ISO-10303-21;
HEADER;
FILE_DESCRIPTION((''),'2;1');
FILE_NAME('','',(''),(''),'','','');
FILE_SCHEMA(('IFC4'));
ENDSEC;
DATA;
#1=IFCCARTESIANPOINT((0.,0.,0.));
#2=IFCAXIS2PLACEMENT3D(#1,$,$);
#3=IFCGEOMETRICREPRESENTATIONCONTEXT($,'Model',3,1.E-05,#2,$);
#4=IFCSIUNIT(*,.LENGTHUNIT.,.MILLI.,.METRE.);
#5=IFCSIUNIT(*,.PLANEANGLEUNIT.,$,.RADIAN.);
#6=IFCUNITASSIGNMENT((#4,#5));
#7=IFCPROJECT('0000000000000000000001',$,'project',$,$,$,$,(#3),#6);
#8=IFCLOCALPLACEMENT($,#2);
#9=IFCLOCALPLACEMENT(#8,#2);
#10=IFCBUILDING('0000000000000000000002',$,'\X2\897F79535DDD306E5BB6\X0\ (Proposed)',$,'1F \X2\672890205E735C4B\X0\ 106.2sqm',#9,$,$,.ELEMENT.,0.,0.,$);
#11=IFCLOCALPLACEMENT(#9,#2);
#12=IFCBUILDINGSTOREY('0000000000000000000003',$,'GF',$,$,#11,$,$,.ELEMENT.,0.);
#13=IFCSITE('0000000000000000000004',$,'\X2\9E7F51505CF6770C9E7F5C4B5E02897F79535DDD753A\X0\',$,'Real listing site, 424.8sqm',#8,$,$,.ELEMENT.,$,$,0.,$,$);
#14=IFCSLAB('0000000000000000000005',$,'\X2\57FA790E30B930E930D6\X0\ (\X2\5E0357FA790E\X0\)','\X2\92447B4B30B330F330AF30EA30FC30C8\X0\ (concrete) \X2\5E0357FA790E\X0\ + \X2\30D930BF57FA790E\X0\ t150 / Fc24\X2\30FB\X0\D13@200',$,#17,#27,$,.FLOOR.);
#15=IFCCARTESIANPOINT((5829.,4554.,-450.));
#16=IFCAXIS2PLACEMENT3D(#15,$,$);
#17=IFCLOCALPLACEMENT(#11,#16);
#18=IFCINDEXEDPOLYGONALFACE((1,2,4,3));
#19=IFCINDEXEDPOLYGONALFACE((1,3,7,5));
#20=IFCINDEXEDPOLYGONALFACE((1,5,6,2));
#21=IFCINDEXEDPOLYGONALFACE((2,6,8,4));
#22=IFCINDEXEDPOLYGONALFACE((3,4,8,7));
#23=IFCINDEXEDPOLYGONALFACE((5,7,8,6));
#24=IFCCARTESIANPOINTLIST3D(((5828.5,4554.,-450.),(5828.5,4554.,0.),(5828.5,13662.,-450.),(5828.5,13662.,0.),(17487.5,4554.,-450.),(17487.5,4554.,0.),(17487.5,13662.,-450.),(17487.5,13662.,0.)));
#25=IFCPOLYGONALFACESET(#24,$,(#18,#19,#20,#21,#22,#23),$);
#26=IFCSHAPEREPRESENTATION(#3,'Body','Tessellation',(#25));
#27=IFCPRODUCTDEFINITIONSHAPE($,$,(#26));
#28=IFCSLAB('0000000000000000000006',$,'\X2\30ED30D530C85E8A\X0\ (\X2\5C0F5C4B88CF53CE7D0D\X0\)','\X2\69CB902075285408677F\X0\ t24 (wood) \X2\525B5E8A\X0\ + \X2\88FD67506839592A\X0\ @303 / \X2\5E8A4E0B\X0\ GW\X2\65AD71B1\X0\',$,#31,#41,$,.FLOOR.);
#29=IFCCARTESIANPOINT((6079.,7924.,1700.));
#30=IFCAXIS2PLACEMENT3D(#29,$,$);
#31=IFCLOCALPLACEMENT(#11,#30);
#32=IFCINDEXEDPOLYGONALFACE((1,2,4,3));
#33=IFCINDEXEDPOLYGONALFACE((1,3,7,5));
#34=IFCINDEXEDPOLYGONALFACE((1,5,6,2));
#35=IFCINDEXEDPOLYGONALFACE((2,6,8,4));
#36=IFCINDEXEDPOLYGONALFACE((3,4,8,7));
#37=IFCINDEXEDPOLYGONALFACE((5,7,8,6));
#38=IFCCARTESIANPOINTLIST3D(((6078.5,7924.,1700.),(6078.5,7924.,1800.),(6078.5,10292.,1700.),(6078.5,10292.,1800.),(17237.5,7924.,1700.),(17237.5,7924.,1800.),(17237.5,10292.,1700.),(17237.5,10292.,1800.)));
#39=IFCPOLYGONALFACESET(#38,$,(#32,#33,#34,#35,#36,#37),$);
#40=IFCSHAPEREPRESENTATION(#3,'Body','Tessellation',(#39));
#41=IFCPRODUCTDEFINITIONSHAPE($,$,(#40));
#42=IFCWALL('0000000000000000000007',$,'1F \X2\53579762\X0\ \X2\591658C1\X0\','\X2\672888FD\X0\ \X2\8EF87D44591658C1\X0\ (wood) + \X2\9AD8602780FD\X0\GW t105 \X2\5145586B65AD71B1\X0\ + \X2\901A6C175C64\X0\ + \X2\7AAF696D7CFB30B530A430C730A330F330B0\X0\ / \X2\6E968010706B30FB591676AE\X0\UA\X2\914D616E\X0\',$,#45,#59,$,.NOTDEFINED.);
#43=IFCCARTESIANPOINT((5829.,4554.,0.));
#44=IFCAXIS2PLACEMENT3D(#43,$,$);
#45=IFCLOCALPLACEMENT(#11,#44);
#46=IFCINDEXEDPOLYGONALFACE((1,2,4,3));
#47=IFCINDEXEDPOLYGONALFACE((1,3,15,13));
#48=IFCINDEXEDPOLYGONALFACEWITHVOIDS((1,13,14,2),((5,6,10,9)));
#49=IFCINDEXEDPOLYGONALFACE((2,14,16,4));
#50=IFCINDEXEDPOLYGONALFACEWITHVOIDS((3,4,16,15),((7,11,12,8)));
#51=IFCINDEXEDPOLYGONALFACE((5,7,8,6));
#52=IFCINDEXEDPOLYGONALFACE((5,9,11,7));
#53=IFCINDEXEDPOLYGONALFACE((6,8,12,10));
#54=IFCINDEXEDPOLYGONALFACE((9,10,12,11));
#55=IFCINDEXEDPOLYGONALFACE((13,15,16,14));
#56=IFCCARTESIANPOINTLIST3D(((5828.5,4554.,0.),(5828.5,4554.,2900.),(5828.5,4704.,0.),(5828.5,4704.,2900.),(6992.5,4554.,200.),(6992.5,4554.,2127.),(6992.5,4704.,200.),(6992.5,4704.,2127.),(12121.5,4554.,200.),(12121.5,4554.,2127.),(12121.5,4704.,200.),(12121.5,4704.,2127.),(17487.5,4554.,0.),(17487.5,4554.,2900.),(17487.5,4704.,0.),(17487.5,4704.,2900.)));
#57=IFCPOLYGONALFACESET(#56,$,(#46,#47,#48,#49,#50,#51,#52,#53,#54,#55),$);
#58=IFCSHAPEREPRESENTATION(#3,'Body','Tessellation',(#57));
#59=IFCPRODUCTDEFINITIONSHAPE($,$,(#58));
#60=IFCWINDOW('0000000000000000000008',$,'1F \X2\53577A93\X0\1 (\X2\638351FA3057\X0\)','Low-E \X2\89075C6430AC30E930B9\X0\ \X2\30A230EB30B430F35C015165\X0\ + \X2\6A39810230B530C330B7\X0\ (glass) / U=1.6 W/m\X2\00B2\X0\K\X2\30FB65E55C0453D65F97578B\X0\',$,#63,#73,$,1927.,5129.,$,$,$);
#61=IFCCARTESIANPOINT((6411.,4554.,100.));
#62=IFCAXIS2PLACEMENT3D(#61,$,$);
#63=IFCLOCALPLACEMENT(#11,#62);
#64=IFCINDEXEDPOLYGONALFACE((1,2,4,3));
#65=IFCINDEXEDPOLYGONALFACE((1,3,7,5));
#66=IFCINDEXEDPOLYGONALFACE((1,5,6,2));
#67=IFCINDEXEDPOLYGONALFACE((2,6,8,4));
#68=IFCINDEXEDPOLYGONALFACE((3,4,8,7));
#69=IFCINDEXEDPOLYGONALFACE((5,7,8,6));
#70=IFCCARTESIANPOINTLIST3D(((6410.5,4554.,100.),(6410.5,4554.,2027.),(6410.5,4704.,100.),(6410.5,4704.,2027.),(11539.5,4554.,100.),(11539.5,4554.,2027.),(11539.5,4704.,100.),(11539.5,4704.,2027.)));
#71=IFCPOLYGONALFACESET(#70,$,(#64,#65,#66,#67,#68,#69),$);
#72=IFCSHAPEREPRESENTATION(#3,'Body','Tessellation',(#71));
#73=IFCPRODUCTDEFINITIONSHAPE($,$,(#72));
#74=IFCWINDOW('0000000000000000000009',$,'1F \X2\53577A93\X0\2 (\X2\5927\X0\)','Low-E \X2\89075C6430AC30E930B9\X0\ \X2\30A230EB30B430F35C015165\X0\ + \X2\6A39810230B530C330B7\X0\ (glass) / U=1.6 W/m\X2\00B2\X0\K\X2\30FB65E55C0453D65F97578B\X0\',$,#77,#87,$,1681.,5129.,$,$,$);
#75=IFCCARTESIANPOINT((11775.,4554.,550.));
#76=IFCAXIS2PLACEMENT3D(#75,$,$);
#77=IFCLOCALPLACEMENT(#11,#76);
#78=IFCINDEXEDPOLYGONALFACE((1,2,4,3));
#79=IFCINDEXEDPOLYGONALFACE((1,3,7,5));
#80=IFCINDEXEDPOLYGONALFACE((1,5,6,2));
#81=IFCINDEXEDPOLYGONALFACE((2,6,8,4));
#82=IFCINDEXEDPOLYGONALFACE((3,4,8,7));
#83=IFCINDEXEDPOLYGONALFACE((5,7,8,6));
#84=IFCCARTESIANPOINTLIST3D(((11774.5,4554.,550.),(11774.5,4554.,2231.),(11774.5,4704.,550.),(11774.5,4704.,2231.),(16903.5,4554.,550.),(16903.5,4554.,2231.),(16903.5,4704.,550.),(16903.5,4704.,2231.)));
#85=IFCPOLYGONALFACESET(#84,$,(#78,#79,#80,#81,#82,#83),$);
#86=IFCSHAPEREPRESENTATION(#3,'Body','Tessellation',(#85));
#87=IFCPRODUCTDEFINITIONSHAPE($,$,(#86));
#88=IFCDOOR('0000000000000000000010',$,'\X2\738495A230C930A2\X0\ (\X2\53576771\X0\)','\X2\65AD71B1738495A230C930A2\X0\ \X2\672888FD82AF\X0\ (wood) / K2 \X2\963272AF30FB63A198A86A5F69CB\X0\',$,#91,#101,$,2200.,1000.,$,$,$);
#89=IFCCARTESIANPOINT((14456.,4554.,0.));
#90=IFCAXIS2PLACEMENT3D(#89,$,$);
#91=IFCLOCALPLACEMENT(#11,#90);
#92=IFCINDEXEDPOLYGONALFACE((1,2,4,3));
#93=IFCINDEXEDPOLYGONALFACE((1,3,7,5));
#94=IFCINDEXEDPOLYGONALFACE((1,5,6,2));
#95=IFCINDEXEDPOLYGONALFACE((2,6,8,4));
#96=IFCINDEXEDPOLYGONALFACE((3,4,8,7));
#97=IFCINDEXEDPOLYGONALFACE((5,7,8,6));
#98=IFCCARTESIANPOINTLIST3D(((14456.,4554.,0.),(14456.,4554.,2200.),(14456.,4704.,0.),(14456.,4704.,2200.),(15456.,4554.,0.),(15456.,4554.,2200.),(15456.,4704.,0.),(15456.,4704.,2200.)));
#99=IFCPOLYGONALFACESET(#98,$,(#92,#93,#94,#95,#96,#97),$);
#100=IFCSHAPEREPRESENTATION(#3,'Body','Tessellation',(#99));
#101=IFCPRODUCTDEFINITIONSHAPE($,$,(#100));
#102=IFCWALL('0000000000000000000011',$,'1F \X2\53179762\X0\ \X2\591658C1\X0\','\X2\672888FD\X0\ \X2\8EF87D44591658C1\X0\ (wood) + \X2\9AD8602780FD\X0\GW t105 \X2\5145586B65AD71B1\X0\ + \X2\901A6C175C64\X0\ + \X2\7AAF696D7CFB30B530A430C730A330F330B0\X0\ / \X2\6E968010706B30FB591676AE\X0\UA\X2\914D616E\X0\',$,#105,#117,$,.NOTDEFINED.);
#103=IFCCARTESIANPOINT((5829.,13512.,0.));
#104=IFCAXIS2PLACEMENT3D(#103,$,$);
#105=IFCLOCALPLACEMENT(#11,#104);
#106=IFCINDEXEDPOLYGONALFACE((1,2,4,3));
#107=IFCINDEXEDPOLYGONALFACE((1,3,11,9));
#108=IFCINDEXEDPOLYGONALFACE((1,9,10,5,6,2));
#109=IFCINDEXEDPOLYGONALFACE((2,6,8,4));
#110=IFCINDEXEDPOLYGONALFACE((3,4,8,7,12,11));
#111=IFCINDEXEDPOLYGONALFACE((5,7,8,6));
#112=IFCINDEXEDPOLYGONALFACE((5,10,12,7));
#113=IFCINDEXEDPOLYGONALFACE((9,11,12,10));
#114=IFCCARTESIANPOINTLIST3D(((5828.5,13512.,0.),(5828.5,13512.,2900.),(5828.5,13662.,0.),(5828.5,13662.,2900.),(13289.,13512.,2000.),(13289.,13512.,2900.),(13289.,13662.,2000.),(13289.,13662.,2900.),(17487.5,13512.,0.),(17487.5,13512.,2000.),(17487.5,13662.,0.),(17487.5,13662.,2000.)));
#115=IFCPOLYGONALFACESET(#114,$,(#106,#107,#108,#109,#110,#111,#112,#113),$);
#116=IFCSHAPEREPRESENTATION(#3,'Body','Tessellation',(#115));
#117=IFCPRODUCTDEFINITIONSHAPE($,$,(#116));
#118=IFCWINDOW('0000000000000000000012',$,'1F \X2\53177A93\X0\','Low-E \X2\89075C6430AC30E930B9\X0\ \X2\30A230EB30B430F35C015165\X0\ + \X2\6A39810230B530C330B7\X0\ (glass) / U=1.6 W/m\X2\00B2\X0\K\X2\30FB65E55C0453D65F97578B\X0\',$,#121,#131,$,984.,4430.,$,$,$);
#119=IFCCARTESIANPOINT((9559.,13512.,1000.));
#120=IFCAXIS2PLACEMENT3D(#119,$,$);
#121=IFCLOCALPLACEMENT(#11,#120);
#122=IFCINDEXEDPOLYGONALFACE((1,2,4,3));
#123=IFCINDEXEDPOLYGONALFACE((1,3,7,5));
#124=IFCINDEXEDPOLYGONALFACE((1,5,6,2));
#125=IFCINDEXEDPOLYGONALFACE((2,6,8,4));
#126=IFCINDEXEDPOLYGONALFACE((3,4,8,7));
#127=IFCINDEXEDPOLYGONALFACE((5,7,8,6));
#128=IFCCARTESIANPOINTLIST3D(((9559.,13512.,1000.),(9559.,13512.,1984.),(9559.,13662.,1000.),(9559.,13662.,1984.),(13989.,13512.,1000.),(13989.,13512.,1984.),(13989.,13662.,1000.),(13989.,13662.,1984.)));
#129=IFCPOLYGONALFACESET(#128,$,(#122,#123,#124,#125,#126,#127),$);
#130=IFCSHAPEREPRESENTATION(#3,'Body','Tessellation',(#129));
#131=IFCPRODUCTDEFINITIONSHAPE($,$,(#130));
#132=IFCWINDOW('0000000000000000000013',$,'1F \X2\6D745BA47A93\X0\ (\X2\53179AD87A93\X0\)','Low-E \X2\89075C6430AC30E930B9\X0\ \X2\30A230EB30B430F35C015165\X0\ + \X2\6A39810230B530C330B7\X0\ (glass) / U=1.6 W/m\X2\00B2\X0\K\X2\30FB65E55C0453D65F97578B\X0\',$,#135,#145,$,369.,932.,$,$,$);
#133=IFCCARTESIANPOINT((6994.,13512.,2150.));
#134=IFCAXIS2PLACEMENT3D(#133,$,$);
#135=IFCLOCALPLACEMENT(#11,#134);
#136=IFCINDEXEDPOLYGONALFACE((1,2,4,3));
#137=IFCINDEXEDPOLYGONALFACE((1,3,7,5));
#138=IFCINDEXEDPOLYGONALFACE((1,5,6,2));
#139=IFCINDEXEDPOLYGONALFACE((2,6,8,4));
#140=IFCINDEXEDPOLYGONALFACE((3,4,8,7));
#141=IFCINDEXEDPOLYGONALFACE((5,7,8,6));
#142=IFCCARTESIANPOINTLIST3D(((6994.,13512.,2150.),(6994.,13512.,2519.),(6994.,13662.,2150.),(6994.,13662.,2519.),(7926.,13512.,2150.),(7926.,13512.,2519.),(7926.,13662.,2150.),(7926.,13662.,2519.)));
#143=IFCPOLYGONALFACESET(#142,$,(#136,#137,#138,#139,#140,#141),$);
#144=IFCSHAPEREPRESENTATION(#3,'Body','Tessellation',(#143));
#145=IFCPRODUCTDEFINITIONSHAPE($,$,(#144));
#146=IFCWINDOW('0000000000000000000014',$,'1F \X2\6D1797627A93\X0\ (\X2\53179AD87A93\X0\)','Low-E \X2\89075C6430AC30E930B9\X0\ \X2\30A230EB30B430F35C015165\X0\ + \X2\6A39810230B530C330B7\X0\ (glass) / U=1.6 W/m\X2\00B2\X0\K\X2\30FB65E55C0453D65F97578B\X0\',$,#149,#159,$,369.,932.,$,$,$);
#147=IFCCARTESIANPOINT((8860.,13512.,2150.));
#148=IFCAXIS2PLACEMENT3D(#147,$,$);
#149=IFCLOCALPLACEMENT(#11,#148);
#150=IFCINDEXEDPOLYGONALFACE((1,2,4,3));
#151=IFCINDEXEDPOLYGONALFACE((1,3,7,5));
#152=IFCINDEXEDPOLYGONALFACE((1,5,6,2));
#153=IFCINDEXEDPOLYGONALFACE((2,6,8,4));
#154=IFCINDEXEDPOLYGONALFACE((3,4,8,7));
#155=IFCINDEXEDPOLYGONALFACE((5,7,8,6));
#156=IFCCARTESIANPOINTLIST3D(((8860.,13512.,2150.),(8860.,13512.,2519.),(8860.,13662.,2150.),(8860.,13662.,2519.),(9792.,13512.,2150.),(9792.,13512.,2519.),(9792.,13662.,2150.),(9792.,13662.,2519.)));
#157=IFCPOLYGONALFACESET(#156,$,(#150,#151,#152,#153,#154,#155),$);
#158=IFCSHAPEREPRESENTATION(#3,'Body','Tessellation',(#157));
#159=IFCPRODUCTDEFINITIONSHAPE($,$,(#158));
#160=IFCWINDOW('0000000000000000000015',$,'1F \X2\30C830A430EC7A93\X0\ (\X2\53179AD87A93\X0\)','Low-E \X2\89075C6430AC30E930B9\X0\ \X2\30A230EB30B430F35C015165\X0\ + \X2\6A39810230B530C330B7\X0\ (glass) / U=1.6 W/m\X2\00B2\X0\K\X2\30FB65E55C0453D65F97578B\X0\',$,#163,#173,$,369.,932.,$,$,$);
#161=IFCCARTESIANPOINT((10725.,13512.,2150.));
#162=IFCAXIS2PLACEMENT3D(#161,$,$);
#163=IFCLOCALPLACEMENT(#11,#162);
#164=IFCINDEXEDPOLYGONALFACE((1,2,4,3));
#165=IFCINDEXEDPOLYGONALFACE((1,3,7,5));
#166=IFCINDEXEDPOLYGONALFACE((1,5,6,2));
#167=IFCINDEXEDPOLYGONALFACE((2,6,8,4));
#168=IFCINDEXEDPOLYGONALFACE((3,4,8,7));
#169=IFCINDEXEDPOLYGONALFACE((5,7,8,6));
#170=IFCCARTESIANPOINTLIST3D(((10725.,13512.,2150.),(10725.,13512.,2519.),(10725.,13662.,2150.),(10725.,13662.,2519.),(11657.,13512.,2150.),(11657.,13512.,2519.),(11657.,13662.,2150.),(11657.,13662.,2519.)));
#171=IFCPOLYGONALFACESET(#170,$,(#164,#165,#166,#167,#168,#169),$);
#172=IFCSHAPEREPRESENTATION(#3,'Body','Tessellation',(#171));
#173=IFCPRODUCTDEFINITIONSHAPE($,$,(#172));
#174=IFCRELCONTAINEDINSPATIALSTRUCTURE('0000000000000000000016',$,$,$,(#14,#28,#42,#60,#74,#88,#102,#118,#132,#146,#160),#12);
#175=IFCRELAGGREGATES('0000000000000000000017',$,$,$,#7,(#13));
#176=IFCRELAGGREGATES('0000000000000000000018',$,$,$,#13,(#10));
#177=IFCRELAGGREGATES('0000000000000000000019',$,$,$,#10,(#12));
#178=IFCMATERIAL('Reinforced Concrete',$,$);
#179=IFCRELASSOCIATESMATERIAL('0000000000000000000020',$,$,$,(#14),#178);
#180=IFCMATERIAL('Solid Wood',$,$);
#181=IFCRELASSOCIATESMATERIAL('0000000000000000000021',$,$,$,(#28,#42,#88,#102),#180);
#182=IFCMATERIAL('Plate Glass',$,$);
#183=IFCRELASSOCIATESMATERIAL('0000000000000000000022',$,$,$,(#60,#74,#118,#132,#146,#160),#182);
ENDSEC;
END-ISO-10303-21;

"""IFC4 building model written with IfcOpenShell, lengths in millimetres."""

from ifc_helpers import new_model, si_unit, frame, frame_2d, origin, place, context, project, spatial, rectangle, extrude, material, element, fill, save


model = new_model("IFC4")

# Units and contexts
model_context = context("Model", 3, precision=1e-05, world=origin())
ifc_project = project(units=[si_unit("LENGTHUNIT", "METRE", prefix="MILLI"), si_unit("PLANEANGLEUNIT", "RADIAN")], contexts=[model_context])

# Site, building, storey
site_placement = place(None, origin())
site = spatial("IfcSite", under=ifc_project, at=site_placement, Name="鹿児島県鹿屋市西祓川町", ObjectType="Real listing site, 424.8sqm", CompositionType="ELEMENT", RefElevation=0.0)
building_placement = place(site_placement, origin())
building = spatial("IfcBuilding", under=site, at=building_placement, Name="西祓川の家 (Proposed)", ObjectType="1F 木造平屋 106.2sqm", CompositionType="ELEMENT", ElevationOfRefHeight=0.0, ElevationOfTerrain=0.0)
storey_placement = place(building_placement, origin())
storey = spatial("IfcBuildingStorey", under=building, at=storey_placement, Name="GF", CompositionType="ELEMENT", Elevation=0.0)

# Slabs
ifc_material_1 = material(Name="Reinforced Concrete")
slab_1_placement = place(storey_placement, frame((5829.0, 4554.0, -450.0)))
element("IfcSlab", 1, at=slab_1_placement, inside=storey, material=ifc_material_1, Name="基礎スラブ (布基礎)", Description="鉄筋コンクリート (concrete) 布基礎 + ベタ基礎 t150 / Fc24・D13@200", PredefinedType="FLOOR", context=model_context, shape_type="SweptSolid", body=[
    extrude(rectangle(XDim=11659.0, YDim=9108.0, at=frame_2d((5829.0, 4554.0))), frame((5829.0, 4554.0, -450.0)), (0.0, 0.0, 1.0), 450.0),
])
ifc_material_2 = material(Name="Solid Wood")
slab_2_placement = place(storey_placement, frame((6079.0, 7924.0, 1700.0)))
element("IfcSlab", 2, at=slab_2_placement, inside=storey, material=ifc_material_2, Name="ロフト床 (小屋裏収納)", Description="構造用合板 t24 (wood) 剛床 + 製材根太 @303 / 床下 GW断熱", PredefinedType="FLOOR", context=model_context, shape_type="SweptSolid", body=[
    extrude(rectangle(XDim=11159.0, YDim=2368.0, at=frame_2d((5579.0, 1184.0))), frame((6079.0, 7924.0, 1700.0)), (0.0, 0.0, 1.0), 100.0),
])

# Wall, openings, windows, door
wall_1_placement = place(storey_placement, frame((5829.0, 4554.0, 0.0)))
wall_1 = element("IfcWall", 3, at=wall_1_placement, inside=storey, material=ifc_material_2, Name="1F 南面 外壁", Description="木製 軸組外壁 (wood) + 高性能GW t105 充填断熱 + 通気層 + 窯業系サイディング / 準耐火・外皮UA配慮", PredefinedType="NOTDEFINED", context=model_context, shape_type="SweptSolid", body=[
    extrude(rectangle(XDim=11659.0, YDim=150.0, at=frame_2d((5829.0, 75.0))), frame((5829.0, 4554.0, 0.0)), (0.0, 0.0, 1.0), 2900.0),
])
opening_1_placement = place(storey_placement, frame((6411.0, 4554.0, 100.0)))
opening_1 = element("IfcOpeningElement", 4, at=opening_1_placement, cuts=wall_1, PredefinedType="NOTDEFINED", context=model_context, shape_type="SweptSolid", body=[
    extrude(rectangle(XDim=5129.0, YDim=150.0, at=frame_2d((2564.0, 75.0))), frame((6411.0, 4554.0, 100.0)), (0.0, 0.0, 1.0), 1927.0),
])
opening_2_placement = place(storey_placement, frame((11775.0, 4554.0, 550.0)))
opening_2 = element("IfcOpeningElement", 5, at=opening_2_placement, cuts=wall_1, PredefinedType="NOTDEFINED", context=model_context, shape_type="SweptSolid", body=[
    extrude(rectangle(XDim=5129.0, YDim=150.0, at=frame_2d((2564.0, 75.0))), frame((11775.0, 4554.0, 550.0)), (0.0, 0.0, 1.0), 1681.0),
])
opening_3_placement = place(storey_placement, frame((14456.0, 4554.0, 0.0)))
opening_3 = element("IfcOpeningElement", 6, at=opening_3_placement, cuts=wall_1, PredefinedType="NOTDEFINED", context=model_context, shape_type="SweptSolid", body=[
    extrude(rectangle(XDim=1000.0, YDim=150.0, at=frame_2d((500.0, 75.0))), frame((14456.0, 4554.0, 0.0)), (0.0, 0.0, 1.0), 2200.0),
])
ifc_material_3 = material(Name="Plate Glass")
window_1_placement = place(storey_placement, frame((6411.0, 4554.0, 100.0)))
window_1 = element("IfcWindow", 7, at=window_1_placement, inside=storey, material=ifc_material_3, Name="1F 南窓1 (掃出し)", Description="Low-E 複層ガラス アルゴン封入 + 樹脂サッシ (glass) / U=1.6 W/m²K・日射取得型", OverallHeight=1927.0, OverallWidth=5129.0, context=model_context, shape_type="SweptSolid", body=[
    extrude(rectangle(XDim=5129.0, YDim=150.0, at=frame_2d((2564.0, 75.0))), frame((6411.0, 4554.0, 100.0)), (0.0, 0.0, 1.0), 1927.0),
])
fill(opening_1, window_1)
window_2_placement = place(storey_placement, frame((11775.0, 4554.0, 550.0)))
window_2 = element("IfcWindow", 8, at=window_2_placement, inside=storey, material=ifc_material_3, Name="1F 南窓2 (大)", Description="Low-E 複層ガラス アルゴン封入 + 樹脂サッシ (glass) / U=1.6 W/m²K・日射取得型", OverallHeight=1681.0, OverallWidth=5129.0, context=model_context, shape_type="SweptSolid", body=[
    extrude(rectangle(XDim=5129.0, YDim=150.0, at=frame_2d((2564.0, 75.0))), frame((11775.0, 4554.0, 550.0)), (0.0, 0.0, 1.0), 1681.0),
])
fill(opening_2, window_2)
door_1_placement = place(storey_placement, frame((14456.0, 4554.0, 0.0)))
door_1 = element("IfcDoor", 9, at=door_1_placement, inside=storey, material=ifc_material_2, Name="玄関ドア (南東)", Description="断熱玄関ドア 木製芯 (wood) / K2 防犯・採風機構", OverallHeight=2200.0, OverallWidth=1000.0, context=model_context, shape_type="SweptSolid", body=[
    extrude(rectangle(XDim=1000.0, YDim=150.0, at=frame_2d((500.0, 75.0))), frame((14456.0, 4554.0, 0.0)), (0.0, 0.0, 1.0), 2200.0),
])
fill(opening_3, door_1)

# Wall, openings, windows
wall_2_placement = place(storey_placement, frame((5829.0, 13512.0, 0.0)))
wall_2 = element("IfcWall", 10, at=wall_2_placement, inside=storey, material=ifc_material_2, Name="1F 北面 外壁", Description="木製 軸組外壁 (wood) + 高性能GW t105 充填断熱 + 通気層 + 窯業系サイディング / 準耐火・外皮UA配慮", PredefinedType="NOTDEFINED", context=model_context, shape_type="SweptSolid", body=[
    extrude(rectangle(XDim=11659.0, YDim=150.0, at=frame_2d((5829.0, 75.0))), frame((5829.0, 13512.0, 0.0)), (0.0, 0.0, 1.0), 2900.0),
])
opening_4_placement = place(storey_placement, frame((9559.0, 13512.0, 1000.0)))
opening_4 = element("IfcOpeningElement", 11, at=opening_4_placement, cuts=wall_2, PredefinedType="NOTDEFINED", context=model_context, shape_type="SweptSolid", body=[
    extrude(rectangle(XDim=4430.0, YDim=150.0, at=frame_2d((2215.0, 75.0))), frame((9559.0, 13512.0, 1000.0)), (0.0, 0.0, 1.0), 984.0),
])
opening_5_placement = place(storey_placement, frame((6994.0, 13512.0, 2150.0)))
opening_5 = element("IfcOpeningElement", 12, at=opening_5_placement, cuts=wall_2, PredefinedType="NOTDEFINED", context=model_context, shape_type="SweptSolid", body=[
    extrude(rectangle(XDim=932.0, YDim=150.0, at=frame_2d((466.0, 75.0))), frame((6994.0, 13512.0, 2150.0)), (0.0, 0.0, 1.0), 369.0),
])
opening_6_placement = place(storey_placement, frame((8860.0, 13512.0, 2150.0)))
opening_6 = element("IfcOpeningElement", 13, at=opening_6_placement, cuts=wall_2, PredefinedType="NOTDEFINED", context=model_context, shape_type="SweptSolid", body=[
    extrude(rectangle(XDim=932.0, YDim=150.0, at=frame_2d((466.0, 75.0))), frame((8860.0, 13512.0, 2150.0)), (0.0, 0.0, 1.0), 369.0),
])
opening_7_placement = place(storey_placement, frame((10725.0, 13512.0, 2150.0)))
opening_7 = element("IfcOpeningElement", 14, at=opening_7_placement, cuts=wall_2, PredefinedType="NOTDEFINED", context=model_context, shape_type="SweptSolid", body=[
    extrude(rectangle(XDim=932.0, YDim=150.0, at=frame_2d((466.0, 75.0))), frame((10725.0, 13512.0, 2150.0)), (0.0, 0.0, 1.0), 369.0),
])
window_3_placement = place(storey_placement, frame((9559.0, 13512.0, 1000.0)))
window_3 = element("IfcWindow", 15, at=window_3_placement, inside=storey, material=ifc_material_3, Name="1F 北窓", Description="Low-E 複層ガラス アルゴン封入 + 樹脂サッシ (glass) / U=1.6 W/m²K・日射取得型", OverallHeight=984.0, OverallWidth=4430.0, context=model_context, shape_type="SweptSolid", body=[
    extrude(rectangle(XDim=4430.0, YDim=150.0, at=frame_2d((2215.0, 75.0))), frame((9559.0, 13512.0, 1000.0)), (0.0, 0.0, 1.0), 984.0),
])
fill(opening_4, window_3)
window_4_placement = place(storey_placement, frame((6994.0, 13512.0, 2150.0)))
window_4 = element("IfcWindow", 16, at=window_4_placement, inside=storey, material=ifc_material_3, Name="1F 浴室窓 (北高窓)", Description="Low-E 複層ガラス アルゴン封入 + 樹脂サッシ (glass) / U=1.6 W/m²K・日射取得型", OverallHeight=369.0, OverallWidth=932.0, context=model_context, shape_type="SweptSolid", body=[
    extrude(rectangle(XDim=932.0, YDim=150.0, at=frame_2d((466.0, 75.0))), frame((6994.0, 13512.0, 2150.0)), (0.0, 0.0, 1.0), 369.0),
])
fill(opening_5, window_4)
window_5_placement = place(storey_placement, frame((8860.0, 13512.0, 2150.0)))
window_5 = element("IfcWindow", 17, at=window_5_placement, inside=storey, material=ifc_material_3, Name="1F 洗面窓 (北高窓)", Description="Low-E 複層ガラス アルゴン封入 + 樹脂サッシ (glass) / U=1.6 W/m²K・日射取得型", OverallHeight=369.0, OverallWidth=932.0, context=model_context, shape_type="SweptSolid", body=[
    extrude(rectangle(XDim=932.0, YDim=150.0, at=frame_2d((466.0, 75.0))), frame((8860.0, 13512.0, 2150.0)), (0.0, 0.0, 1.0), 369.0),
])
fill(opening_6, window_5)
window_6_placement = place(storey_placement, frame((10725.0, 13512.0, 2150.0)))
window_6 = element("IfcWindow", 18, at=window_6_placement, inside=storey, material=ifc_material_3, Name="1F トイレ窓 (北高窓)", Description="Low-E 複層ガラス アルゴン封入 + 樹脂サッシ (glass) / U=1.6 W/m²K・日射取得型", OverallHeight=369.0, OverallWidth=932.0, context=model_context, shape_type="SweptSolid", body=[
    extrude(rectangle(XDim=932.0, YDim=150.0, at=frame_2d((466.0, 75.0))), frame((10725.0, 13512.0, 2150.0)), (0.0, 0.0, 1.0), 369.0),
])
fill(opening_7, window_6)

save(model, "model.ifc")
